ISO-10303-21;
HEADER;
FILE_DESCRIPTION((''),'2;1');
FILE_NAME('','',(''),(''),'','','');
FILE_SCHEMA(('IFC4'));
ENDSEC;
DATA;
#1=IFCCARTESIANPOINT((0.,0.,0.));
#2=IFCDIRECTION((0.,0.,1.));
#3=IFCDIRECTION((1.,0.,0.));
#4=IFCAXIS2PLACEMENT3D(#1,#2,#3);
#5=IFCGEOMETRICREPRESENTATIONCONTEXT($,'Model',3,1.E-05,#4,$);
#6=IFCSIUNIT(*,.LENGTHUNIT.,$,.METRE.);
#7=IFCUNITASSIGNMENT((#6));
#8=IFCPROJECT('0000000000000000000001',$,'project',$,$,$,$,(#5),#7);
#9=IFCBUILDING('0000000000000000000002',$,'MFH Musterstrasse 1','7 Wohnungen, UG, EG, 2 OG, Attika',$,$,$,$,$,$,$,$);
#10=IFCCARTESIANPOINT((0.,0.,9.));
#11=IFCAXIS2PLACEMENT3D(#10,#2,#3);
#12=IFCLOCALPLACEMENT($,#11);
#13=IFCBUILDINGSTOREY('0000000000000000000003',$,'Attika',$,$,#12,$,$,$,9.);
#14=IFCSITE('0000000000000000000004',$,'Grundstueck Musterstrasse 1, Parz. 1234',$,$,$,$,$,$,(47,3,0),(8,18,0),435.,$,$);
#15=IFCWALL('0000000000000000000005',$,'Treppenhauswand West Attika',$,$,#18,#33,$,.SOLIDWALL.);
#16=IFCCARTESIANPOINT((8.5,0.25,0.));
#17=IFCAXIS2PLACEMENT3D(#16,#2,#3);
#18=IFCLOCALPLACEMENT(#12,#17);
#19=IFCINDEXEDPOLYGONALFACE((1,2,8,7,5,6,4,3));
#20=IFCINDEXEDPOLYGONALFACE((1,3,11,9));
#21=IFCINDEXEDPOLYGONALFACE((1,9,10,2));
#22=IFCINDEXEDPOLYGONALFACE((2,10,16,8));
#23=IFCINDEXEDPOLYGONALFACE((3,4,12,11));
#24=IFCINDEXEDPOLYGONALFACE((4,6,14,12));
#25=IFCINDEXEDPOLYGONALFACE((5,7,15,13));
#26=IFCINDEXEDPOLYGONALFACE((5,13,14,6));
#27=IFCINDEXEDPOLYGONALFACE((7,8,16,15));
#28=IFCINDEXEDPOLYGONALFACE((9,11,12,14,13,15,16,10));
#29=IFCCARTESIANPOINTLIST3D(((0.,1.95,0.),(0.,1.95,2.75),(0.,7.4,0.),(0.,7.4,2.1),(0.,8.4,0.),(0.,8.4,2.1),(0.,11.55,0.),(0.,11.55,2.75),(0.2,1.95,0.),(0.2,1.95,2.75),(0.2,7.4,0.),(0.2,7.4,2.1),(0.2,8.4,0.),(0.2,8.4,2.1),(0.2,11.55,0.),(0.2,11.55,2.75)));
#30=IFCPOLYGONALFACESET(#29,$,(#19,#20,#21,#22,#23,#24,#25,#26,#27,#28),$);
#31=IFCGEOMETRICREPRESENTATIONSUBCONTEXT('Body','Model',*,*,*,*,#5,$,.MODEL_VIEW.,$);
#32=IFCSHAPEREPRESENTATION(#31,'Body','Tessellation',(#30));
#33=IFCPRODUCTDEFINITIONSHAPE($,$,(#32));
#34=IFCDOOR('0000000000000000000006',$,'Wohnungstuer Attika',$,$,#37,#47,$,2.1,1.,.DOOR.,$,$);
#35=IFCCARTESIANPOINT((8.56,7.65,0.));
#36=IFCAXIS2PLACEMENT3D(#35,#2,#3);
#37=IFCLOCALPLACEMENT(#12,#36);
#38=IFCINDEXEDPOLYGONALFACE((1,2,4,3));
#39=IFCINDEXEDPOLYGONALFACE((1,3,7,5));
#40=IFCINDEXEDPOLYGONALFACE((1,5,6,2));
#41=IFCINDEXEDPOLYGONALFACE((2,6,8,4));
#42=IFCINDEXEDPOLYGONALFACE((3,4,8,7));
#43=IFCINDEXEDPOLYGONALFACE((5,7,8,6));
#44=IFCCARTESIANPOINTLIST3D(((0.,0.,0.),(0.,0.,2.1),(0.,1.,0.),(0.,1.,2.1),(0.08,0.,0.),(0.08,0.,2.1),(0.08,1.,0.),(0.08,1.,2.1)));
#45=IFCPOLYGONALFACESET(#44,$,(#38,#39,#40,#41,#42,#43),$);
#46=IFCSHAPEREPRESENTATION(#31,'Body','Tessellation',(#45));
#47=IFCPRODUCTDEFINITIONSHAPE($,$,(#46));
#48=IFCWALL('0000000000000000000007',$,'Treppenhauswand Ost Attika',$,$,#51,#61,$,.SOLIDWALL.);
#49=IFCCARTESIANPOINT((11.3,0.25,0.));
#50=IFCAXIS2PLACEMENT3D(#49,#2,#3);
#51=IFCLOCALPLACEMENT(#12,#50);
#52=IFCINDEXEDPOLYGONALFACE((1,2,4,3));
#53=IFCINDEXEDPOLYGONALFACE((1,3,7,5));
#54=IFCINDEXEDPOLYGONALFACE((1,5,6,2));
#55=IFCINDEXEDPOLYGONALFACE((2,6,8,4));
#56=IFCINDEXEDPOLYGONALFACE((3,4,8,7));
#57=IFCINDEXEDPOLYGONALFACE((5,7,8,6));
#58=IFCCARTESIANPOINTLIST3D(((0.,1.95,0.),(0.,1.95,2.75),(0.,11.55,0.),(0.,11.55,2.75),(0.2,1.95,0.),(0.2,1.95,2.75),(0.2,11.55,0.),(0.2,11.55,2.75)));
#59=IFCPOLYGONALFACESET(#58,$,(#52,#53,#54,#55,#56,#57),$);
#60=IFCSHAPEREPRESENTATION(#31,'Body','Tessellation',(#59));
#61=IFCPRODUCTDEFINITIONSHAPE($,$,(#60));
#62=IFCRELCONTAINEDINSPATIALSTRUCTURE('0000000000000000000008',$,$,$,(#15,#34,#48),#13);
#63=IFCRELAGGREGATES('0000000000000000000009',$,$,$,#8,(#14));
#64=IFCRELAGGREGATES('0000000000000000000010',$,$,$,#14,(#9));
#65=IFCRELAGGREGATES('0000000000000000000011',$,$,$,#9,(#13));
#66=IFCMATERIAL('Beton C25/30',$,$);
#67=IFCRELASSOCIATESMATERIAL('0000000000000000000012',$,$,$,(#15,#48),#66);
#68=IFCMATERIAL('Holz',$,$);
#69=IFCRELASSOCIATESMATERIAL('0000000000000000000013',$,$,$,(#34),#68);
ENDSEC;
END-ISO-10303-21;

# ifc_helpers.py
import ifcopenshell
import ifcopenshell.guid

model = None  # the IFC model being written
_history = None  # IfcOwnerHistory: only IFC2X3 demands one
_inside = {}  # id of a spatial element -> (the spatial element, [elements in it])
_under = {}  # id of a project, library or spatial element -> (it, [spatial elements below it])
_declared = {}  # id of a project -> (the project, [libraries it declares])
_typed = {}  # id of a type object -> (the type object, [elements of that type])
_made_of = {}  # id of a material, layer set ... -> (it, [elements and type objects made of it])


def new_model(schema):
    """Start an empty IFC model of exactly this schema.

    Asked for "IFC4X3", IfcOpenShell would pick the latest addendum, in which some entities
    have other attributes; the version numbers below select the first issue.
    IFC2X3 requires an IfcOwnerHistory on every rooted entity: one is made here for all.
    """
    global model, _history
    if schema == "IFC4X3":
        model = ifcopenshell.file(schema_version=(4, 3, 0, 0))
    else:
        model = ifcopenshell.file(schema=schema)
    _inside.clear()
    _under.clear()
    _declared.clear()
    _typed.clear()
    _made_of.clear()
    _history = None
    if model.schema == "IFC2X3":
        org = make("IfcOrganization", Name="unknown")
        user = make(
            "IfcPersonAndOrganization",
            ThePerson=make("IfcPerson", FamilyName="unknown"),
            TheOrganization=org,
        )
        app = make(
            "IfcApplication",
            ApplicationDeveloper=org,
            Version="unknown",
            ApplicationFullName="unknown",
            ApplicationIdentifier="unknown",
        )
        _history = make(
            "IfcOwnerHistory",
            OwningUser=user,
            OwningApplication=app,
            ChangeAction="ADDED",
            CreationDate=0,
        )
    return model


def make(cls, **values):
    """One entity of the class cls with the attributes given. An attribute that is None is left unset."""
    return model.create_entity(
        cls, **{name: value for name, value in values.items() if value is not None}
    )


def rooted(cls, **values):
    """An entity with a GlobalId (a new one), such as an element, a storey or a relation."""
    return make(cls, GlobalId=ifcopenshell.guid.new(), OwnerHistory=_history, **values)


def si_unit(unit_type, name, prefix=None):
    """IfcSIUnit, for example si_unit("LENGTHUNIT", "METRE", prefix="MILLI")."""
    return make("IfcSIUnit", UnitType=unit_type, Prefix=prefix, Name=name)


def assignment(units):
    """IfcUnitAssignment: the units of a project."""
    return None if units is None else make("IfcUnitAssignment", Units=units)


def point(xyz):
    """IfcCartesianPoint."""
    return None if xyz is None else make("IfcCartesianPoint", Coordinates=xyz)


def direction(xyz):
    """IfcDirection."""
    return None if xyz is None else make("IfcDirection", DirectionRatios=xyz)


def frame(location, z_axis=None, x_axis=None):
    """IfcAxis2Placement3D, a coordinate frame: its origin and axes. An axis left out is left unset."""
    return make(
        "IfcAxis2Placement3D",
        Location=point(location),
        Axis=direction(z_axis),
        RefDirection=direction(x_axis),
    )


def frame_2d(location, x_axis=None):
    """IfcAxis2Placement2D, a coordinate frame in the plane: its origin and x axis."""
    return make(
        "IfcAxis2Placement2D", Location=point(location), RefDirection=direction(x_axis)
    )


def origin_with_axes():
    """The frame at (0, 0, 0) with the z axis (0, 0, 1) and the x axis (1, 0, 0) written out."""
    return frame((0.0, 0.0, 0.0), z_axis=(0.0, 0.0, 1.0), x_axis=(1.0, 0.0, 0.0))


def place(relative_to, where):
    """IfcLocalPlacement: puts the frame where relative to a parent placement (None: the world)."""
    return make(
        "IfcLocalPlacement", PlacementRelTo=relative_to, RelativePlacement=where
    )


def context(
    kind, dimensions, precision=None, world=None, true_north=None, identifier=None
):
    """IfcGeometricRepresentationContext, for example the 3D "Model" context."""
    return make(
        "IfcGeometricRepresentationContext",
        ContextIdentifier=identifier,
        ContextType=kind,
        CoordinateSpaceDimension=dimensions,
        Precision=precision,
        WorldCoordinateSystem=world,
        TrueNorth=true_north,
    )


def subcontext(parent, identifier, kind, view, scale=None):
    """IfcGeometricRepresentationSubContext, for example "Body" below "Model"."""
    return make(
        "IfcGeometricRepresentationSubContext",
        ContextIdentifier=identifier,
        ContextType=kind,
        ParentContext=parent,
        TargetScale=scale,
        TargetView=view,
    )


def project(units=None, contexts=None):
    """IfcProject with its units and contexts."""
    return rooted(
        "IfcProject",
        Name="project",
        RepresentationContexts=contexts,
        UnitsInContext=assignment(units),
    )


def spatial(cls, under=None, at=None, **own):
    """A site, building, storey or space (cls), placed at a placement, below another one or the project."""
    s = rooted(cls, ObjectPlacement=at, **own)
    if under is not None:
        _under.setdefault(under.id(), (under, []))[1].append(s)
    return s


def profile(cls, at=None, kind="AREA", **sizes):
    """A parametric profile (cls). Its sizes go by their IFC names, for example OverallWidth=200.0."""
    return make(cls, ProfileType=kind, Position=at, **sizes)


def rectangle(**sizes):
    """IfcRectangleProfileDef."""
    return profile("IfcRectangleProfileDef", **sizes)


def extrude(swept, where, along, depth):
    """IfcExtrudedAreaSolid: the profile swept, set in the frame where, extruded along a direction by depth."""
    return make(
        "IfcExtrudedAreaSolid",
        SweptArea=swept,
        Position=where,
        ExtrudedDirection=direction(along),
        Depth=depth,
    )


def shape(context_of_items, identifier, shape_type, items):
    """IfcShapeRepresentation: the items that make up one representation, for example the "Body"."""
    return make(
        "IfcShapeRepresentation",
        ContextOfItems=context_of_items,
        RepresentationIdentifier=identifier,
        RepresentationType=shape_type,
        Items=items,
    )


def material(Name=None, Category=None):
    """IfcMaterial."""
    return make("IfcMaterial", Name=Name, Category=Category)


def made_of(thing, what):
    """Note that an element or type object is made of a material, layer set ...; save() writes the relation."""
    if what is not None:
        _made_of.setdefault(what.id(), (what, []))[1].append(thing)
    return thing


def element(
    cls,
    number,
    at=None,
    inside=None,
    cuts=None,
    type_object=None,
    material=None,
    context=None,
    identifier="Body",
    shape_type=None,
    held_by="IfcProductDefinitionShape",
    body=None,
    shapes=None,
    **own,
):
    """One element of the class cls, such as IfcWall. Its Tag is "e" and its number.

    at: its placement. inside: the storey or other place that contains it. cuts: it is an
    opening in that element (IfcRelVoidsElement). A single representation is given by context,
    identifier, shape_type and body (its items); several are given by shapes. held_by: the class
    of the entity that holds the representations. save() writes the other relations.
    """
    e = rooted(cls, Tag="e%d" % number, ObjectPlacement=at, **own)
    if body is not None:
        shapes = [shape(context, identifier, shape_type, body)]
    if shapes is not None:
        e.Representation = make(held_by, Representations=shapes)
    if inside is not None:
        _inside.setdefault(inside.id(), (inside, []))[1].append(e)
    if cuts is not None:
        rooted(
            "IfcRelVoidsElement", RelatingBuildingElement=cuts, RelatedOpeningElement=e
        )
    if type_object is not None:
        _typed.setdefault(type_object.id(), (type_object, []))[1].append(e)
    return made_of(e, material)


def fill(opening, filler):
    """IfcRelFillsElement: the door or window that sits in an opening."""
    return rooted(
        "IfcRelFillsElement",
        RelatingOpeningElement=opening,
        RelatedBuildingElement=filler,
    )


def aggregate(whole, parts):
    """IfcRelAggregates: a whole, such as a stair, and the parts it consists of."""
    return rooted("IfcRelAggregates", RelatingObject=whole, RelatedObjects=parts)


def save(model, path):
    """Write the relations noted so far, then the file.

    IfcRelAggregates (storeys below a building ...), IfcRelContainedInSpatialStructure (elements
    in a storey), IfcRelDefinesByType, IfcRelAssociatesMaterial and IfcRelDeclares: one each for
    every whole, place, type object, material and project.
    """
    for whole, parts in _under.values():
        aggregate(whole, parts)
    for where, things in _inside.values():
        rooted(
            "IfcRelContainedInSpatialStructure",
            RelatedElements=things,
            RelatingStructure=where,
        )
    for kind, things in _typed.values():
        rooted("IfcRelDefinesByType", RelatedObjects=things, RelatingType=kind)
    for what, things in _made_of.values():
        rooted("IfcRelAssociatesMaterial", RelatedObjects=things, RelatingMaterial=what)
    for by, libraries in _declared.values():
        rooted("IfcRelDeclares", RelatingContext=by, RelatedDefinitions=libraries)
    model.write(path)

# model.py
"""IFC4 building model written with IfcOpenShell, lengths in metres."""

from ifc_helpers import new_model, si_unit, frame, frame_2d, origin_with_axes, place, context, subcontext, project, spatial, rectangle, extrude, material, element, fill, save


model = new_model("IFC4")

# Units and contexts
model_context = context("Model", 3, precision=1e-05, world=origin_with_axes())
body_context = subcontext(model_context, "Body", "Model", "MODEL_VIEW")
ifc_project = project(units=[si_unit("LENGTHUNIT", "METRE")], contexts=[model_context])

# Site, building, storey
site = spatial("IfcSite", under=ifc_project, Name="Grundstueck Musterstrasse 1, Parz. 1234", RefLatitude=(47, 3, 0), RefLongitude=(8, 18, 0), RefElevation=435.0)
building = spatial("IfcBuilding", under=site, Name="MFH Musterstrasse 1", Description="7 Wohnungen, UG, EG, 2 OG, Attika")
storey_placement = place(None, frame((0.0, 0.0, 9.0), z_axis=(0.0, 0.0, 1.0), x_axis=(1.0, 0.0, 0.0)))
storey = spatial("IfcBuildingStorey", under=building, at=storey_placement, Name="Attika", Elevation=9.0)

# Wall, opening, door
ifc_material_1 = material(Name="Beton C25/30")
wall_1_placement = place(storey_placement, frame((8.5, 0.25, 0.0), z_axis=(0.0, 0.0, 1.0), x_axis=(1.0, 0.0, 0.0)))
wall_1 = element("IfcWall", 1, at=wall_1_placement, inside=storey, material=ifc_material_1, Name="Treppenhauswand West Attika", PredefinedType="SOLIDWALL", context=body_context, shape_type="SweptSolid", body=[
    extrude(rectangle(XDim=0.2, YDim=9.6, at=frame_2d((0.1, 6.75))), origin_with_axes(), (0.0, 0.0, 1.0), 2.75),
])
opening_1_placement = place(wall_1_placement, frame((-0.01, 7.4, 0.0), z_axis=(0.0, 0.0, 1.0), x_axis=(1.0, 0.0, 0.0)))
opening_1 = element("IfcOpeningElement", 2, at=opening_1_placement, cuts=wall_1, context=body_context, shape_type="SweptSolid", body=[
    extrude(rectangle(XDim=0.22, YDim=1.0, at=frame_2d((0.11, 0.5))), origin_with_axes(), (0.0, 0.0, 1.0), 2.1),
])
ifc_material_2 = material(Name="Holz")
door_1_placement = place(storey_placement, frame((8.56, 7.65, 0.0), z_axis=(0.0, 0.0, 1.0), x_axis=(1.0, 0.0, 0.0)))
door_1 = element("IfcDoor", 3, at=door_1_placement, inside=storey, material=ifc_material_2, Name="Wohnungstuer Attika", OverallHeight=2.1, OverallWidth=1.0, PredefinedType="DOOR", context=body_context, shape_type="SweptSolid", body=[
    extrude(rectangle(XDim=0.08, YDim=1.0, at=frame_2d((0.04, 0.5))), origin_with_axes(), (0.0, 0.0, 1.0), 2.1),
])
fill(opening_1, door_1)

# Wall
wall_2_placement = place(storey_placement, frame((11.3, 0.25, 0.0), z_axis=(0.0, 0.0, 1.0), x_axis=(1.0, 0.0, 0.0)))
element("IfcWall", 4, at=wall_2_placement, inside=storey, material=ifc_material_1, Name="Treppenhauswand Ost Attika", PredefinedType="SOLIDWALL", context=body_context, shape_type="SweptSolid", body=[
    extrude(rectangle(XDim=0.2, YDim=9.6, at=frame_2d((0.1, 6.75))), origin_with_axes(), (0.0, 0.0, 1.0), 2.75),
])

save(model, "model.ifc")
